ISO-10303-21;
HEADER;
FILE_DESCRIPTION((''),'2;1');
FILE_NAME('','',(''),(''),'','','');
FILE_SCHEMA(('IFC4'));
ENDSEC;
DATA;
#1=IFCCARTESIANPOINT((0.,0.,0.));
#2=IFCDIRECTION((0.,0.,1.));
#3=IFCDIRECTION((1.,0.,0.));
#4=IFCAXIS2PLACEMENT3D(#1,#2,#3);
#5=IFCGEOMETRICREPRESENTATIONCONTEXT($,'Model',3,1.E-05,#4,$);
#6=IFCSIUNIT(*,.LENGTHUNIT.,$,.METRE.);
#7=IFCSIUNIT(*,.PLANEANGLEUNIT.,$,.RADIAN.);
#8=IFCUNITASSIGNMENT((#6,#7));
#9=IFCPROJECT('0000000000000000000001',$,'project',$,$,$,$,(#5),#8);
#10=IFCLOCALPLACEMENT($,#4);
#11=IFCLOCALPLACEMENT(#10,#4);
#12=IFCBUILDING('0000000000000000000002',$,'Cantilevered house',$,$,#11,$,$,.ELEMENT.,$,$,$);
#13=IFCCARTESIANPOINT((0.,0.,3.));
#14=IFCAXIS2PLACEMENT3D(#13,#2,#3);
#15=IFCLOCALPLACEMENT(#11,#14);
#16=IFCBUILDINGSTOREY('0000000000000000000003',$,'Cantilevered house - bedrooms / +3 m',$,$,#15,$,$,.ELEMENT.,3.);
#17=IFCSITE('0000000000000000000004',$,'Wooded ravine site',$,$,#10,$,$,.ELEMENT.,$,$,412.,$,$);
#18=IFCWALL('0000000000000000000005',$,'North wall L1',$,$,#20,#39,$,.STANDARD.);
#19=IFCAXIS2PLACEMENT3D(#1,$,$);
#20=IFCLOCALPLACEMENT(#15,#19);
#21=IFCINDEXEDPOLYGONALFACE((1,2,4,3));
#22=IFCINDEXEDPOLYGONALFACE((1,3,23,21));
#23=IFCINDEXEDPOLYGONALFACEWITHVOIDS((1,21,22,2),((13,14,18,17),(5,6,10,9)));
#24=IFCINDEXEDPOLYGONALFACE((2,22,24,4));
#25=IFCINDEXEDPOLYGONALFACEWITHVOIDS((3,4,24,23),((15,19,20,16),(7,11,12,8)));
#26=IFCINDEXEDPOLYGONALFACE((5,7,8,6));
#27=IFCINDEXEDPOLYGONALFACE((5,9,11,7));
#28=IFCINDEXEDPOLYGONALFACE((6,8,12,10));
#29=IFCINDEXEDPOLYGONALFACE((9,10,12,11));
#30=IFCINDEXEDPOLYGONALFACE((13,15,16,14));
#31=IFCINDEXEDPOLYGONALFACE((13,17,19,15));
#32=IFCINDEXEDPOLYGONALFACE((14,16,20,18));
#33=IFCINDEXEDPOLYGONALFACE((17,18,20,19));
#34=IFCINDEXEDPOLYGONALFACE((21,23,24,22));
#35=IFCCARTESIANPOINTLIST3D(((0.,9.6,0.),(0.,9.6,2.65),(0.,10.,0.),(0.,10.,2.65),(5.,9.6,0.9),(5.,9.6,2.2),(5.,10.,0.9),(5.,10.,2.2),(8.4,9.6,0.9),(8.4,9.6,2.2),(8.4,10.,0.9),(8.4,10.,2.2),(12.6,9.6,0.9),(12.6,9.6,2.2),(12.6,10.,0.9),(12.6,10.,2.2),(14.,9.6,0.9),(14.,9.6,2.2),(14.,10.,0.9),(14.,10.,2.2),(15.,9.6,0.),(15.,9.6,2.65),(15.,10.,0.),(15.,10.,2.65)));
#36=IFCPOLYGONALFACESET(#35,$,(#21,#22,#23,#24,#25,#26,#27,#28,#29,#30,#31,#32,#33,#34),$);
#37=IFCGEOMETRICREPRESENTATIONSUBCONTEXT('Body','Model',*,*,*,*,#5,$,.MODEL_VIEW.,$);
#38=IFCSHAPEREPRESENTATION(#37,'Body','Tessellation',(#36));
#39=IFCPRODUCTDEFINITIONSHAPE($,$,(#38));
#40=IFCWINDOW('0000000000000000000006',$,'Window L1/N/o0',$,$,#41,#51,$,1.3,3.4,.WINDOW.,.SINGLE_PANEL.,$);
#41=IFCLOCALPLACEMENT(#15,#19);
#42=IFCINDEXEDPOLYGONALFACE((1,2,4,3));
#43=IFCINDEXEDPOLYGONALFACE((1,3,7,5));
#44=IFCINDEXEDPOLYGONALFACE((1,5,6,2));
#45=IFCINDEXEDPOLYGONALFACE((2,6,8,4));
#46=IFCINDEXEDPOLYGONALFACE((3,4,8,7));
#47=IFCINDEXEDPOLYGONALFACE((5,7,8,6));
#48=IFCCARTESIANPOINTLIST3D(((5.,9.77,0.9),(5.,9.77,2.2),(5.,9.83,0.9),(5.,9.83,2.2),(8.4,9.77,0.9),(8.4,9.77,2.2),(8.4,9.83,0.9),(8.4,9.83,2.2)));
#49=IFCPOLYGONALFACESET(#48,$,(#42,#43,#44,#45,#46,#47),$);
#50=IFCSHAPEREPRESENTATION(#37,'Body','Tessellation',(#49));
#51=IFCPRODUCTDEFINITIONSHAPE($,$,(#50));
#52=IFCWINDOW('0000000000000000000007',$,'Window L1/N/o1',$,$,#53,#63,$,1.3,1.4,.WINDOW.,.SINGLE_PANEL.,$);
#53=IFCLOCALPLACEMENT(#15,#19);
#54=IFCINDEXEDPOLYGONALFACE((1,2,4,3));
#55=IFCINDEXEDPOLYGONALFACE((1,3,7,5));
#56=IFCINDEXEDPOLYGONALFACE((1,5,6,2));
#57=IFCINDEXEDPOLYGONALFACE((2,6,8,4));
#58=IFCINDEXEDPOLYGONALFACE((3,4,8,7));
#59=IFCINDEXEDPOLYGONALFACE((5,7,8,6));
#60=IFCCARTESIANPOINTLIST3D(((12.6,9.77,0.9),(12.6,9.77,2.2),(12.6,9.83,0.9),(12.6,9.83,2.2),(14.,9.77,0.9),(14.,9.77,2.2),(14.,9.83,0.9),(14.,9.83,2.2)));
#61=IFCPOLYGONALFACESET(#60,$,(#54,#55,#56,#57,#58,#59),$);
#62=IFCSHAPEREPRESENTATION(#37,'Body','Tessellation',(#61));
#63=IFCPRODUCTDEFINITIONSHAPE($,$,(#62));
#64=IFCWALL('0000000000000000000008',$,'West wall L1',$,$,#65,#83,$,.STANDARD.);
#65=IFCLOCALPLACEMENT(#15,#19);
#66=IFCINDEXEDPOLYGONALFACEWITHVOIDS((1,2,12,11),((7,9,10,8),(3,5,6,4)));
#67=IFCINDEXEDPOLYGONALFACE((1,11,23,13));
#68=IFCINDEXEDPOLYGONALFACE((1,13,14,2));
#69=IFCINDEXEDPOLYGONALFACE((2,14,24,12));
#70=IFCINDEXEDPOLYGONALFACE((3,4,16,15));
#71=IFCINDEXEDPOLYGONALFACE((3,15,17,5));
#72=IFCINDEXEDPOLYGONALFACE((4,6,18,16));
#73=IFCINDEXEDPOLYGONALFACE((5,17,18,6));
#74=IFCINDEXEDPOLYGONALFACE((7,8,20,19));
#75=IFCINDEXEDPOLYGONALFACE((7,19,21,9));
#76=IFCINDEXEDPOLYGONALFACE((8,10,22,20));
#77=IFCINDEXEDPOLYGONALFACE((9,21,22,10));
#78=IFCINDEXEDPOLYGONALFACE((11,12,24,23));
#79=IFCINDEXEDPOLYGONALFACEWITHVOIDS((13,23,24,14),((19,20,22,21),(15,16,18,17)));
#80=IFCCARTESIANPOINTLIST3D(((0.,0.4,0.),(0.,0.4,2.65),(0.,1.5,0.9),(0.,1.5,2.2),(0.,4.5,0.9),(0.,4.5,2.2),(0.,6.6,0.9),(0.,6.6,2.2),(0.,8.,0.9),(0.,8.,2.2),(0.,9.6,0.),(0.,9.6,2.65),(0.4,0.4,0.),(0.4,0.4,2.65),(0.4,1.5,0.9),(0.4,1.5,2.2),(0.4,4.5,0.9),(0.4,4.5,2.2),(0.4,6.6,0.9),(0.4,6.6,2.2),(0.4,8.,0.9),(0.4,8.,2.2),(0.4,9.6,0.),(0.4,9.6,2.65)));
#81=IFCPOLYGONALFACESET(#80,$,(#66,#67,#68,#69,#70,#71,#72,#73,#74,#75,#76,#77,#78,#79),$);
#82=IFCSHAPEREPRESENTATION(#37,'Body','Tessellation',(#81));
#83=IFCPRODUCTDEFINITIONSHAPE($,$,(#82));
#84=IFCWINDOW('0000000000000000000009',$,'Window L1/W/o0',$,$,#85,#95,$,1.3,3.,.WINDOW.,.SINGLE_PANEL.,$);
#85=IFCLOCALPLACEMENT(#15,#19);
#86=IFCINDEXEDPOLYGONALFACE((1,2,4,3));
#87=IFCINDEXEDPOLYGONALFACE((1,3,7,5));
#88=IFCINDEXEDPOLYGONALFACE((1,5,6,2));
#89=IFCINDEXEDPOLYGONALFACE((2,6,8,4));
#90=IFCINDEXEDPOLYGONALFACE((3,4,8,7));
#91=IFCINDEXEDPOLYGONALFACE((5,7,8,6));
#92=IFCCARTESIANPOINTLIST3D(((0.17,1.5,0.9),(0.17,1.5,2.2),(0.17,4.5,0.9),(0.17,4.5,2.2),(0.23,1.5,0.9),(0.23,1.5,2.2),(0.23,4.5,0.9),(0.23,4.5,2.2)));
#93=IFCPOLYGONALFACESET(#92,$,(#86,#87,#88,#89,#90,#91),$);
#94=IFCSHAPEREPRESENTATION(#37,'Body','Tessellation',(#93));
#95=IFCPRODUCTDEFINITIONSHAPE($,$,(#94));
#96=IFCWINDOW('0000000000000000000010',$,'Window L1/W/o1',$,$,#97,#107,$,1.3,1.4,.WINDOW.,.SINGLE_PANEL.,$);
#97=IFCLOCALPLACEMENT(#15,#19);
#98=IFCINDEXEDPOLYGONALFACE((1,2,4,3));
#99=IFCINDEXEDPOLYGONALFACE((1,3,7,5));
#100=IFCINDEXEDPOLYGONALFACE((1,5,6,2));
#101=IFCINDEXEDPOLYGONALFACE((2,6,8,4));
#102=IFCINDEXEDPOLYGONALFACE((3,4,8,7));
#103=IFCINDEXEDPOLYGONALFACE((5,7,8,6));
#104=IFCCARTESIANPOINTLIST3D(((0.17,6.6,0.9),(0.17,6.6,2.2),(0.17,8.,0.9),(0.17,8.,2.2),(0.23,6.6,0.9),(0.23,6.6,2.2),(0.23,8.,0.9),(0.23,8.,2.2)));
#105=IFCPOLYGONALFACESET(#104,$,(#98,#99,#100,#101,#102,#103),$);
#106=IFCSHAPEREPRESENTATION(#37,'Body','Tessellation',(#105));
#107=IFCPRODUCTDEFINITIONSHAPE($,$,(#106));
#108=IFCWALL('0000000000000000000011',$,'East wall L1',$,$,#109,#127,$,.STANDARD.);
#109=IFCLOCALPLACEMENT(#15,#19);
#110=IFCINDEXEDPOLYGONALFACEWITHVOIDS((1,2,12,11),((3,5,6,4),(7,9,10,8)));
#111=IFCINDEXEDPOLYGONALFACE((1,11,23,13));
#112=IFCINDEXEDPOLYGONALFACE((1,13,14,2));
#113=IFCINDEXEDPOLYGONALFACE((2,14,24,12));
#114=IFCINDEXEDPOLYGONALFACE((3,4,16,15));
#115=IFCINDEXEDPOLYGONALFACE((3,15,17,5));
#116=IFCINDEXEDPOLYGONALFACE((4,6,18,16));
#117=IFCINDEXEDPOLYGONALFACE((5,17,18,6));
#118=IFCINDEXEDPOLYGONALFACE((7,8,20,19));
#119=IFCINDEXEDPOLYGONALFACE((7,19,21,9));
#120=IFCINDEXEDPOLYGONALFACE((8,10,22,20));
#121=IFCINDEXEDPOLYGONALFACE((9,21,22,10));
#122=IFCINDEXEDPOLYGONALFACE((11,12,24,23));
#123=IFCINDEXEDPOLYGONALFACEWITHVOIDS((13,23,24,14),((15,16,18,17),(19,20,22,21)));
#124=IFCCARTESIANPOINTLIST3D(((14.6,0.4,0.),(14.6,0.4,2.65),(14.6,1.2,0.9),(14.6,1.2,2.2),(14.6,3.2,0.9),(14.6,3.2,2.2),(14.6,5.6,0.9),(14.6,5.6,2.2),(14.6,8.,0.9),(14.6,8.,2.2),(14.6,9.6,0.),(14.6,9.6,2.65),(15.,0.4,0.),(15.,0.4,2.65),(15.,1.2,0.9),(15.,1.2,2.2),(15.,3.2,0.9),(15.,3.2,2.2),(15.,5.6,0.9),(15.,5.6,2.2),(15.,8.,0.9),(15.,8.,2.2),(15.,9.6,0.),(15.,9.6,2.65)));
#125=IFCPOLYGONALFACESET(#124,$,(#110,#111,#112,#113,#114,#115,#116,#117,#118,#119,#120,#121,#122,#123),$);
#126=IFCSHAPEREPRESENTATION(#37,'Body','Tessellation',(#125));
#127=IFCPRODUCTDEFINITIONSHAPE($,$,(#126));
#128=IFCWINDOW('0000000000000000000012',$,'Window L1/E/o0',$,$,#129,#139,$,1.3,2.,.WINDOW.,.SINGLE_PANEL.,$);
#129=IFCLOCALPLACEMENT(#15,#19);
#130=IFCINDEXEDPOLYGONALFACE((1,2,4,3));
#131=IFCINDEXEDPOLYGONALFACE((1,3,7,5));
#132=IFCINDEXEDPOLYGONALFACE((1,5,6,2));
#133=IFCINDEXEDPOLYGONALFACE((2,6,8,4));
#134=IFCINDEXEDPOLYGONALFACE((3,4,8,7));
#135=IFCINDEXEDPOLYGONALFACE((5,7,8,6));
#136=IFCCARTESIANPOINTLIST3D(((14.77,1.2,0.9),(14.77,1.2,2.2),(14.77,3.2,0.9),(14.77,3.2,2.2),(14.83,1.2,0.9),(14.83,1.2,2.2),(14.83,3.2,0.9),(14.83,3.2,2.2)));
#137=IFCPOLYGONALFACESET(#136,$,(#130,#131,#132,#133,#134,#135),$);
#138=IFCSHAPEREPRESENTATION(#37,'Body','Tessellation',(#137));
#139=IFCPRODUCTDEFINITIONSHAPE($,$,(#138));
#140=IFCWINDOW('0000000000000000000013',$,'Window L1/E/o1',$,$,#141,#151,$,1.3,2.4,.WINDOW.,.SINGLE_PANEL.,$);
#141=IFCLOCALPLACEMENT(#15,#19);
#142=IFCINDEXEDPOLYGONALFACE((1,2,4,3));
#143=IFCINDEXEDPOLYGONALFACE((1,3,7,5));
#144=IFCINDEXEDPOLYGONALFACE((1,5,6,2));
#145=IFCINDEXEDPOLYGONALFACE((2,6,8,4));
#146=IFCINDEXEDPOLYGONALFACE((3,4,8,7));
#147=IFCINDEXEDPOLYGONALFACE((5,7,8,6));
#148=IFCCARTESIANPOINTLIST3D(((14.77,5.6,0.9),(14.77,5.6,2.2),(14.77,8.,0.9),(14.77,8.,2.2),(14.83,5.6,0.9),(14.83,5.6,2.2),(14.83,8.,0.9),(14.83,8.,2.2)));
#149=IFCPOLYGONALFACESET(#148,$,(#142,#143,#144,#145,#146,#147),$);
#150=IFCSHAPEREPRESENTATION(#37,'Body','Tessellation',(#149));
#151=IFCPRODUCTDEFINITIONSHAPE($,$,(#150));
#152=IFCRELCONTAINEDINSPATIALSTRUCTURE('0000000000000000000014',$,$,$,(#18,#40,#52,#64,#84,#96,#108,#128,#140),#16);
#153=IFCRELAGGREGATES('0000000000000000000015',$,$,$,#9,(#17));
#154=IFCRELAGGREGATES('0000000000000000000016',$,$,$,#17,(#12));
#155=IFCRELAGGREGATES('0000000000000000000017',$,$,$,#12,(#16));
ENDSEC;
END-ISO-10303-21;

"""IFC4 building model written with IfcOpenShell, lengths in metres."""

from ifc_helpers import new_model, si_unit, frame, frame_2d, origin_with_axes, place, context, subcontext, project, spatial, rectangle, extrude, element, fill, save


model = new_model("IFC4")

# Units and contexts
model_context = context("Model", 3, precision=1e-05, world=origin_with_axes())
body_context = subcontext(model_context, "Body", "Model", "MODEL_VIEW")
ifc_project = project(units=[si_unit("LENGTHUNIT", "METRE"), si_unit("PLANEANGLEUNIT", "RADIAN")], contexts=[model_context])

# Site, building, storey
site_placement = place(None, origin_with_axes())
site = spatial("IfcSite", under=ifc_project, at=site_placement, Name="Wooded ravine site", CompositionType="ELEMENT", RefElevation=412.0)
building_placement = place(site_placement, origin_with_axes())
building = spatial("IfcBuilding", under=site, at=building_placement, Name="Cantilevered house", CompositionType="ELEMENT")
storey_placement = place(building_placement, frame((0.0, 0.0, 3.0), z_axis=(0.0, 0.0, 1.0), x_axis=(1.0, 0.0, 0.0)))
storey = spatial("IfcBuildingStorey", under=building, at=storey_placement, Name="Cantilevered house - bedrooms / +3 m", CompositionType="ELEMENT", Elevation=3.0)

# Walls, openings, windows
wall_1_placement = place(storey_placement, origin_with_axes())
wall_1 = element("IfcWall", 1, at=wall_1_placement, inside=storey, Name="North wall L1", PredefinedType="STANDARD", context=body_context, shape_type="SweptSolid", body=[
    extrude(rectangle(XDim=15.0, YDim=0.4, at=frame_2d((7.5, 9.8))), origin_with_axes(), (0.0, 0.0, 1.0), 2.65),
])
opening_1_placement = place(storey_placement, origin_with_axes())
opening_1 = element("IfcOpeningElement", 2, at=opening_1_placement, inside=storey, cuts=wall_1, PredefinedType="OPENING", context=body_context, shape_type="SweptSolid", body=[
    extrude(rectangle(XDim=3.4, YDim=0.44, at=frame_2d((6.7, 9.8))), frame((0.0, 0.0, 0.9), z_axis=(0.0, 0.0, 1.0), x_axis=(1.0, 0.0, 0.0)), (0.0, 0.0, 1.0), 1.3),
])
opening_2_placement = place(storey_placement, origin_with_axes())
opening_2 = element("IfcOpeningElement", 3, at=opening_2_placement, inside=storey, cuts=wall_1, PredefinedType="OPENING", context=body_context, shape_type="SweptSolid", body=[
    extrude(rectangle(XDim=1.4, YDim=0.44, at=frame_2d((13.3, 9.8))), frame((0.0, 0.0, 0.9), z_axis=(0.0, 0.0, 1.0), x_axis=(1.0, 0.0, 0.0)), (0.0, 0.0, 1.0), 1.3),
])
window_1_placement = place(storey_placement, origin_with_axes())
window_1 = element("IfcWindow", 4, at=window_1_placement, inside=storey, Name="Window L1/N/o0", OverallHeight=1.3, OverallWidth=3.4, PartitioningType="SINGLE_PANEL", PredefinedType="WINDOW", context=body_context, shape_type="SweptSolid", body=[
    extrude(rectangle(XDim=3.4, YDim=0.06, at=frame_2d((6.7, 9.8))), frame((0.0, 0.0, 0.9), z_axis=(0.0, 0.0, 1.0), x_axis=(1.0, 0.0, 0.0)), (0.0, 0.0, 1.0), 1.3),
])
fill(opening_1, window_1)
window_2_placement = place(storey_placement, origin_with_axes())
window_2 = element("IfcWindow", 5, at=window_2_placement, inside=storey, Name="Window L1/N/o1", OverallHeight=1.3, OverallWidth=1.4, PartitioningType="SINGLE_PANEL", PredefinedType="WINDOW", context=body_context, shape_type="SweptSolid", body=[
    extrude(rectangle(XDim=1.4, YDim=0.06, at=frame_2d((13.3, 9.8))), frame((0.0, 0.0, 0.9), z_axis=(0.0, 0.0, 1.0), x_axis=(1.0, 0.0, 0.0)), (0.0, 0.0, 1.0), 1.3),
])
fill(opening_2, window_2)
wall_2_placement = place(storey_placement, origin_with_axes())
wall_2 = element("IfcWall", 6, at=wall_2_placement, inside=storey, Name="West wall L1", PredefinedType="STANDARD", context=body_context, shape_type="SweptSolid", body=[
    extrude(rectangle(XDim=0.4, YDim=9.2, at=frame_2d((0.2, 5.0))), origin_with_axes(), (0.0, 0.0, 1.0), 2.65),
])
opening_3_placement = place(storey_placement, origin_with_axes())
opening_3 = element("IfcOpeningElement", 7, at=opening_3_placement, inside=storey, cuts=wall_2, PredefinedType="OPENING", context=body_context, shape_type="SweptSolid", body=[
    extrude(rectangle(XDim=0.44, YDim=3.0, at=frame_2d((0.2, 3.0))), frame((0.0, 0.0, 0.9), z_axis=(0.0, 0.0, 1.0), x_axis=(1.0, 0.0, 0.0)), (0.0, 0.0, 1.0), 1.3),
])
opening_4_placement = place(storey_placement, origin_with_axes())
opening_4 = element("IfcOpeningElement", 8, at=opening_4_placement, inside=storey, cuts=wall_2, PredefinedType="OPENING", context=body_context, shape_type="SweptSolid", body=[
    extrude(rectangle(XDim=0.44, YDim=1.4, at=frame_2d((0.2, 7.3))), frame((0.0, 0.0, 0.9), z_axis=(0.0, 0.0, 1.0), x_axis=(1.0, 0.0, 0.0)), (0.0, 0.0, 1.0), 1.3),
])
window_3_placement = place(storey_placement, origin_with_axes())
window_3 = element("IfcWindow", 9, at=window_3_placement, inside=storey, Name="Window L1/W/o0", OverallHeight=1.3, OverallWidth=3.0, PartitioningType="SINGLE_PANEL", PredefinedType="WINDOW", context=body_context, shape_type="SweptSolid", body=[
    extrude(rectangle(XDim=0.06, YDim=3.0, at=frame_2d((0.2, 3.0))), frame((0.0, 0.0, 0.9), z_axis=(0.0, 0.0, 1.0), x_axis=(1.0, 0.0, 0.0)), (0.0, 0.0, 1.0), 1.3),
])
fill(opening_3, window_3)
window_4_placement = place(storey_placement, origin_with_axes())
window_4 = element("IfcWindow", 10, at=window_4_placement, inside=storey, Name="Window L1/W/o1", OverallHeight=1.3, OverallWidth=1.4, PartitioningType="SINGLE_PANEL", PredefinedType="WINDOW", context=body_context, shape_type="SweptSolid", body=[
    extrude(rectangle(XDim=0.06, YDim=1.4, at=frame_2d((0.2, 7.3))), frame((0.0, 0.0, 0.9), z_axis=(0.0, 0.0, 1.0), x_axis=(1.0, 0.0, 0.0)), (0.0, 0.0, 1.0), 1.3),
])
fill(opening_4, window_4)
wall_3_placement = place(storey_placement, origin_with_axes())
wall_3 = element("IfcWall", 11, at=wall_3_placement, inside=storey, Name="East wall L1", PredefinedType="STANDARD", context=body_context, shape_type="SweptSolid", body=[
    extrude(rectangle(XDim=0.4, YDim=9.2, at=frame_2d((14.8, 5.0))), origin_with_axes(), (0.0, 0.0, 1.0), 2.65),
])
opening_5_placement = place(storey_placement, origin_with_axes())
opening_5 = element("IfcOpeningElement", 12, at=opening_5_placement, inside=storey, cuts=wall_3, PredefinedType="OPENING", context=body_context, shape_type="SweptSolid", body=[
    extrude(rectangle(XDim=0.44, YDim=2.0, at=frame_2d((14.8, 2.2))), frame((0.0, 0.0, 0.9), z_axis=(0.0, 0.0, 1.0), x_axis=(1.0, 0.0, 0.0)), (0.0, 0.0, 1.0), 1.3),
])
opening_6_placement = place(storey_placement, origin_with_axes())
opening_6 = element("IfcOpeningElement", 13, at=opening_6_placement, inside=storey, cuts=wall_3, PredefinedType="OPENING", context=body_context, shape_type="SweptSolid", body=[
    extrude(rectangle(XDim=0.44, YDim=2.4, at=frame_2d((14.8, 6.8))), frame((0.0, 0.0, 0.9), z_axis=(0.0, 0.0, 1.0), x_axis=(1.0, 0.0, 0.0)), (0.0, 0.0, 1.0), 1.3),
])
window_5_placement = place(storey_placement, origin_with_axes())
window_5 = element("IfcWindow", 14, at=window_5_placement, inside=storey, Name="Window L1/E/o0", OverallHeight=1.3, OverallWidth=2.0, PartitioningType="SINGLE_PANEL", PredefinedType="WINDOW", context=body_context, shape_type="SweptSolid", body=[
    extrude(rectangle(XDim=0.06, YDim=2.0, at=frame_2d((14.8, 2.2))), frame((0.0, 0.0, 0.9), z_axis=(0.0, 0.0, 1.0), x_axis=(1.0, 0.0, 0.0)), (0.0, 0.0, 1.0), 1.3),
])
fill(opening_5, window_5)
window_6_placement = place(storey_placement, origin_with_axes())
window_6 = element("IfcWindow", 15, at=window_6_placement, inside=storey, Name="Window L1/E/o1", OverallHeight=1.3, OverallWidth=2.4, PartitioningType="SINGLE_PANEL", PredefinedType="WINDOW", context=body_context, shape_type="SweptSolid", body=[
    extrude(rectangle(XDim=0.06, YDim=2.4, at=frame_2d((14.8, 6.8))), frame((0.0, 0.0, 0.9), z_axis=(0.0, 0.0, 1.0), x_axis=(1.0, 0.0, 0.0)), (0.0, 0.0, 1.0), 1.3),
])
fill(opening_6, window_6)

save(model, "model.ifc")
